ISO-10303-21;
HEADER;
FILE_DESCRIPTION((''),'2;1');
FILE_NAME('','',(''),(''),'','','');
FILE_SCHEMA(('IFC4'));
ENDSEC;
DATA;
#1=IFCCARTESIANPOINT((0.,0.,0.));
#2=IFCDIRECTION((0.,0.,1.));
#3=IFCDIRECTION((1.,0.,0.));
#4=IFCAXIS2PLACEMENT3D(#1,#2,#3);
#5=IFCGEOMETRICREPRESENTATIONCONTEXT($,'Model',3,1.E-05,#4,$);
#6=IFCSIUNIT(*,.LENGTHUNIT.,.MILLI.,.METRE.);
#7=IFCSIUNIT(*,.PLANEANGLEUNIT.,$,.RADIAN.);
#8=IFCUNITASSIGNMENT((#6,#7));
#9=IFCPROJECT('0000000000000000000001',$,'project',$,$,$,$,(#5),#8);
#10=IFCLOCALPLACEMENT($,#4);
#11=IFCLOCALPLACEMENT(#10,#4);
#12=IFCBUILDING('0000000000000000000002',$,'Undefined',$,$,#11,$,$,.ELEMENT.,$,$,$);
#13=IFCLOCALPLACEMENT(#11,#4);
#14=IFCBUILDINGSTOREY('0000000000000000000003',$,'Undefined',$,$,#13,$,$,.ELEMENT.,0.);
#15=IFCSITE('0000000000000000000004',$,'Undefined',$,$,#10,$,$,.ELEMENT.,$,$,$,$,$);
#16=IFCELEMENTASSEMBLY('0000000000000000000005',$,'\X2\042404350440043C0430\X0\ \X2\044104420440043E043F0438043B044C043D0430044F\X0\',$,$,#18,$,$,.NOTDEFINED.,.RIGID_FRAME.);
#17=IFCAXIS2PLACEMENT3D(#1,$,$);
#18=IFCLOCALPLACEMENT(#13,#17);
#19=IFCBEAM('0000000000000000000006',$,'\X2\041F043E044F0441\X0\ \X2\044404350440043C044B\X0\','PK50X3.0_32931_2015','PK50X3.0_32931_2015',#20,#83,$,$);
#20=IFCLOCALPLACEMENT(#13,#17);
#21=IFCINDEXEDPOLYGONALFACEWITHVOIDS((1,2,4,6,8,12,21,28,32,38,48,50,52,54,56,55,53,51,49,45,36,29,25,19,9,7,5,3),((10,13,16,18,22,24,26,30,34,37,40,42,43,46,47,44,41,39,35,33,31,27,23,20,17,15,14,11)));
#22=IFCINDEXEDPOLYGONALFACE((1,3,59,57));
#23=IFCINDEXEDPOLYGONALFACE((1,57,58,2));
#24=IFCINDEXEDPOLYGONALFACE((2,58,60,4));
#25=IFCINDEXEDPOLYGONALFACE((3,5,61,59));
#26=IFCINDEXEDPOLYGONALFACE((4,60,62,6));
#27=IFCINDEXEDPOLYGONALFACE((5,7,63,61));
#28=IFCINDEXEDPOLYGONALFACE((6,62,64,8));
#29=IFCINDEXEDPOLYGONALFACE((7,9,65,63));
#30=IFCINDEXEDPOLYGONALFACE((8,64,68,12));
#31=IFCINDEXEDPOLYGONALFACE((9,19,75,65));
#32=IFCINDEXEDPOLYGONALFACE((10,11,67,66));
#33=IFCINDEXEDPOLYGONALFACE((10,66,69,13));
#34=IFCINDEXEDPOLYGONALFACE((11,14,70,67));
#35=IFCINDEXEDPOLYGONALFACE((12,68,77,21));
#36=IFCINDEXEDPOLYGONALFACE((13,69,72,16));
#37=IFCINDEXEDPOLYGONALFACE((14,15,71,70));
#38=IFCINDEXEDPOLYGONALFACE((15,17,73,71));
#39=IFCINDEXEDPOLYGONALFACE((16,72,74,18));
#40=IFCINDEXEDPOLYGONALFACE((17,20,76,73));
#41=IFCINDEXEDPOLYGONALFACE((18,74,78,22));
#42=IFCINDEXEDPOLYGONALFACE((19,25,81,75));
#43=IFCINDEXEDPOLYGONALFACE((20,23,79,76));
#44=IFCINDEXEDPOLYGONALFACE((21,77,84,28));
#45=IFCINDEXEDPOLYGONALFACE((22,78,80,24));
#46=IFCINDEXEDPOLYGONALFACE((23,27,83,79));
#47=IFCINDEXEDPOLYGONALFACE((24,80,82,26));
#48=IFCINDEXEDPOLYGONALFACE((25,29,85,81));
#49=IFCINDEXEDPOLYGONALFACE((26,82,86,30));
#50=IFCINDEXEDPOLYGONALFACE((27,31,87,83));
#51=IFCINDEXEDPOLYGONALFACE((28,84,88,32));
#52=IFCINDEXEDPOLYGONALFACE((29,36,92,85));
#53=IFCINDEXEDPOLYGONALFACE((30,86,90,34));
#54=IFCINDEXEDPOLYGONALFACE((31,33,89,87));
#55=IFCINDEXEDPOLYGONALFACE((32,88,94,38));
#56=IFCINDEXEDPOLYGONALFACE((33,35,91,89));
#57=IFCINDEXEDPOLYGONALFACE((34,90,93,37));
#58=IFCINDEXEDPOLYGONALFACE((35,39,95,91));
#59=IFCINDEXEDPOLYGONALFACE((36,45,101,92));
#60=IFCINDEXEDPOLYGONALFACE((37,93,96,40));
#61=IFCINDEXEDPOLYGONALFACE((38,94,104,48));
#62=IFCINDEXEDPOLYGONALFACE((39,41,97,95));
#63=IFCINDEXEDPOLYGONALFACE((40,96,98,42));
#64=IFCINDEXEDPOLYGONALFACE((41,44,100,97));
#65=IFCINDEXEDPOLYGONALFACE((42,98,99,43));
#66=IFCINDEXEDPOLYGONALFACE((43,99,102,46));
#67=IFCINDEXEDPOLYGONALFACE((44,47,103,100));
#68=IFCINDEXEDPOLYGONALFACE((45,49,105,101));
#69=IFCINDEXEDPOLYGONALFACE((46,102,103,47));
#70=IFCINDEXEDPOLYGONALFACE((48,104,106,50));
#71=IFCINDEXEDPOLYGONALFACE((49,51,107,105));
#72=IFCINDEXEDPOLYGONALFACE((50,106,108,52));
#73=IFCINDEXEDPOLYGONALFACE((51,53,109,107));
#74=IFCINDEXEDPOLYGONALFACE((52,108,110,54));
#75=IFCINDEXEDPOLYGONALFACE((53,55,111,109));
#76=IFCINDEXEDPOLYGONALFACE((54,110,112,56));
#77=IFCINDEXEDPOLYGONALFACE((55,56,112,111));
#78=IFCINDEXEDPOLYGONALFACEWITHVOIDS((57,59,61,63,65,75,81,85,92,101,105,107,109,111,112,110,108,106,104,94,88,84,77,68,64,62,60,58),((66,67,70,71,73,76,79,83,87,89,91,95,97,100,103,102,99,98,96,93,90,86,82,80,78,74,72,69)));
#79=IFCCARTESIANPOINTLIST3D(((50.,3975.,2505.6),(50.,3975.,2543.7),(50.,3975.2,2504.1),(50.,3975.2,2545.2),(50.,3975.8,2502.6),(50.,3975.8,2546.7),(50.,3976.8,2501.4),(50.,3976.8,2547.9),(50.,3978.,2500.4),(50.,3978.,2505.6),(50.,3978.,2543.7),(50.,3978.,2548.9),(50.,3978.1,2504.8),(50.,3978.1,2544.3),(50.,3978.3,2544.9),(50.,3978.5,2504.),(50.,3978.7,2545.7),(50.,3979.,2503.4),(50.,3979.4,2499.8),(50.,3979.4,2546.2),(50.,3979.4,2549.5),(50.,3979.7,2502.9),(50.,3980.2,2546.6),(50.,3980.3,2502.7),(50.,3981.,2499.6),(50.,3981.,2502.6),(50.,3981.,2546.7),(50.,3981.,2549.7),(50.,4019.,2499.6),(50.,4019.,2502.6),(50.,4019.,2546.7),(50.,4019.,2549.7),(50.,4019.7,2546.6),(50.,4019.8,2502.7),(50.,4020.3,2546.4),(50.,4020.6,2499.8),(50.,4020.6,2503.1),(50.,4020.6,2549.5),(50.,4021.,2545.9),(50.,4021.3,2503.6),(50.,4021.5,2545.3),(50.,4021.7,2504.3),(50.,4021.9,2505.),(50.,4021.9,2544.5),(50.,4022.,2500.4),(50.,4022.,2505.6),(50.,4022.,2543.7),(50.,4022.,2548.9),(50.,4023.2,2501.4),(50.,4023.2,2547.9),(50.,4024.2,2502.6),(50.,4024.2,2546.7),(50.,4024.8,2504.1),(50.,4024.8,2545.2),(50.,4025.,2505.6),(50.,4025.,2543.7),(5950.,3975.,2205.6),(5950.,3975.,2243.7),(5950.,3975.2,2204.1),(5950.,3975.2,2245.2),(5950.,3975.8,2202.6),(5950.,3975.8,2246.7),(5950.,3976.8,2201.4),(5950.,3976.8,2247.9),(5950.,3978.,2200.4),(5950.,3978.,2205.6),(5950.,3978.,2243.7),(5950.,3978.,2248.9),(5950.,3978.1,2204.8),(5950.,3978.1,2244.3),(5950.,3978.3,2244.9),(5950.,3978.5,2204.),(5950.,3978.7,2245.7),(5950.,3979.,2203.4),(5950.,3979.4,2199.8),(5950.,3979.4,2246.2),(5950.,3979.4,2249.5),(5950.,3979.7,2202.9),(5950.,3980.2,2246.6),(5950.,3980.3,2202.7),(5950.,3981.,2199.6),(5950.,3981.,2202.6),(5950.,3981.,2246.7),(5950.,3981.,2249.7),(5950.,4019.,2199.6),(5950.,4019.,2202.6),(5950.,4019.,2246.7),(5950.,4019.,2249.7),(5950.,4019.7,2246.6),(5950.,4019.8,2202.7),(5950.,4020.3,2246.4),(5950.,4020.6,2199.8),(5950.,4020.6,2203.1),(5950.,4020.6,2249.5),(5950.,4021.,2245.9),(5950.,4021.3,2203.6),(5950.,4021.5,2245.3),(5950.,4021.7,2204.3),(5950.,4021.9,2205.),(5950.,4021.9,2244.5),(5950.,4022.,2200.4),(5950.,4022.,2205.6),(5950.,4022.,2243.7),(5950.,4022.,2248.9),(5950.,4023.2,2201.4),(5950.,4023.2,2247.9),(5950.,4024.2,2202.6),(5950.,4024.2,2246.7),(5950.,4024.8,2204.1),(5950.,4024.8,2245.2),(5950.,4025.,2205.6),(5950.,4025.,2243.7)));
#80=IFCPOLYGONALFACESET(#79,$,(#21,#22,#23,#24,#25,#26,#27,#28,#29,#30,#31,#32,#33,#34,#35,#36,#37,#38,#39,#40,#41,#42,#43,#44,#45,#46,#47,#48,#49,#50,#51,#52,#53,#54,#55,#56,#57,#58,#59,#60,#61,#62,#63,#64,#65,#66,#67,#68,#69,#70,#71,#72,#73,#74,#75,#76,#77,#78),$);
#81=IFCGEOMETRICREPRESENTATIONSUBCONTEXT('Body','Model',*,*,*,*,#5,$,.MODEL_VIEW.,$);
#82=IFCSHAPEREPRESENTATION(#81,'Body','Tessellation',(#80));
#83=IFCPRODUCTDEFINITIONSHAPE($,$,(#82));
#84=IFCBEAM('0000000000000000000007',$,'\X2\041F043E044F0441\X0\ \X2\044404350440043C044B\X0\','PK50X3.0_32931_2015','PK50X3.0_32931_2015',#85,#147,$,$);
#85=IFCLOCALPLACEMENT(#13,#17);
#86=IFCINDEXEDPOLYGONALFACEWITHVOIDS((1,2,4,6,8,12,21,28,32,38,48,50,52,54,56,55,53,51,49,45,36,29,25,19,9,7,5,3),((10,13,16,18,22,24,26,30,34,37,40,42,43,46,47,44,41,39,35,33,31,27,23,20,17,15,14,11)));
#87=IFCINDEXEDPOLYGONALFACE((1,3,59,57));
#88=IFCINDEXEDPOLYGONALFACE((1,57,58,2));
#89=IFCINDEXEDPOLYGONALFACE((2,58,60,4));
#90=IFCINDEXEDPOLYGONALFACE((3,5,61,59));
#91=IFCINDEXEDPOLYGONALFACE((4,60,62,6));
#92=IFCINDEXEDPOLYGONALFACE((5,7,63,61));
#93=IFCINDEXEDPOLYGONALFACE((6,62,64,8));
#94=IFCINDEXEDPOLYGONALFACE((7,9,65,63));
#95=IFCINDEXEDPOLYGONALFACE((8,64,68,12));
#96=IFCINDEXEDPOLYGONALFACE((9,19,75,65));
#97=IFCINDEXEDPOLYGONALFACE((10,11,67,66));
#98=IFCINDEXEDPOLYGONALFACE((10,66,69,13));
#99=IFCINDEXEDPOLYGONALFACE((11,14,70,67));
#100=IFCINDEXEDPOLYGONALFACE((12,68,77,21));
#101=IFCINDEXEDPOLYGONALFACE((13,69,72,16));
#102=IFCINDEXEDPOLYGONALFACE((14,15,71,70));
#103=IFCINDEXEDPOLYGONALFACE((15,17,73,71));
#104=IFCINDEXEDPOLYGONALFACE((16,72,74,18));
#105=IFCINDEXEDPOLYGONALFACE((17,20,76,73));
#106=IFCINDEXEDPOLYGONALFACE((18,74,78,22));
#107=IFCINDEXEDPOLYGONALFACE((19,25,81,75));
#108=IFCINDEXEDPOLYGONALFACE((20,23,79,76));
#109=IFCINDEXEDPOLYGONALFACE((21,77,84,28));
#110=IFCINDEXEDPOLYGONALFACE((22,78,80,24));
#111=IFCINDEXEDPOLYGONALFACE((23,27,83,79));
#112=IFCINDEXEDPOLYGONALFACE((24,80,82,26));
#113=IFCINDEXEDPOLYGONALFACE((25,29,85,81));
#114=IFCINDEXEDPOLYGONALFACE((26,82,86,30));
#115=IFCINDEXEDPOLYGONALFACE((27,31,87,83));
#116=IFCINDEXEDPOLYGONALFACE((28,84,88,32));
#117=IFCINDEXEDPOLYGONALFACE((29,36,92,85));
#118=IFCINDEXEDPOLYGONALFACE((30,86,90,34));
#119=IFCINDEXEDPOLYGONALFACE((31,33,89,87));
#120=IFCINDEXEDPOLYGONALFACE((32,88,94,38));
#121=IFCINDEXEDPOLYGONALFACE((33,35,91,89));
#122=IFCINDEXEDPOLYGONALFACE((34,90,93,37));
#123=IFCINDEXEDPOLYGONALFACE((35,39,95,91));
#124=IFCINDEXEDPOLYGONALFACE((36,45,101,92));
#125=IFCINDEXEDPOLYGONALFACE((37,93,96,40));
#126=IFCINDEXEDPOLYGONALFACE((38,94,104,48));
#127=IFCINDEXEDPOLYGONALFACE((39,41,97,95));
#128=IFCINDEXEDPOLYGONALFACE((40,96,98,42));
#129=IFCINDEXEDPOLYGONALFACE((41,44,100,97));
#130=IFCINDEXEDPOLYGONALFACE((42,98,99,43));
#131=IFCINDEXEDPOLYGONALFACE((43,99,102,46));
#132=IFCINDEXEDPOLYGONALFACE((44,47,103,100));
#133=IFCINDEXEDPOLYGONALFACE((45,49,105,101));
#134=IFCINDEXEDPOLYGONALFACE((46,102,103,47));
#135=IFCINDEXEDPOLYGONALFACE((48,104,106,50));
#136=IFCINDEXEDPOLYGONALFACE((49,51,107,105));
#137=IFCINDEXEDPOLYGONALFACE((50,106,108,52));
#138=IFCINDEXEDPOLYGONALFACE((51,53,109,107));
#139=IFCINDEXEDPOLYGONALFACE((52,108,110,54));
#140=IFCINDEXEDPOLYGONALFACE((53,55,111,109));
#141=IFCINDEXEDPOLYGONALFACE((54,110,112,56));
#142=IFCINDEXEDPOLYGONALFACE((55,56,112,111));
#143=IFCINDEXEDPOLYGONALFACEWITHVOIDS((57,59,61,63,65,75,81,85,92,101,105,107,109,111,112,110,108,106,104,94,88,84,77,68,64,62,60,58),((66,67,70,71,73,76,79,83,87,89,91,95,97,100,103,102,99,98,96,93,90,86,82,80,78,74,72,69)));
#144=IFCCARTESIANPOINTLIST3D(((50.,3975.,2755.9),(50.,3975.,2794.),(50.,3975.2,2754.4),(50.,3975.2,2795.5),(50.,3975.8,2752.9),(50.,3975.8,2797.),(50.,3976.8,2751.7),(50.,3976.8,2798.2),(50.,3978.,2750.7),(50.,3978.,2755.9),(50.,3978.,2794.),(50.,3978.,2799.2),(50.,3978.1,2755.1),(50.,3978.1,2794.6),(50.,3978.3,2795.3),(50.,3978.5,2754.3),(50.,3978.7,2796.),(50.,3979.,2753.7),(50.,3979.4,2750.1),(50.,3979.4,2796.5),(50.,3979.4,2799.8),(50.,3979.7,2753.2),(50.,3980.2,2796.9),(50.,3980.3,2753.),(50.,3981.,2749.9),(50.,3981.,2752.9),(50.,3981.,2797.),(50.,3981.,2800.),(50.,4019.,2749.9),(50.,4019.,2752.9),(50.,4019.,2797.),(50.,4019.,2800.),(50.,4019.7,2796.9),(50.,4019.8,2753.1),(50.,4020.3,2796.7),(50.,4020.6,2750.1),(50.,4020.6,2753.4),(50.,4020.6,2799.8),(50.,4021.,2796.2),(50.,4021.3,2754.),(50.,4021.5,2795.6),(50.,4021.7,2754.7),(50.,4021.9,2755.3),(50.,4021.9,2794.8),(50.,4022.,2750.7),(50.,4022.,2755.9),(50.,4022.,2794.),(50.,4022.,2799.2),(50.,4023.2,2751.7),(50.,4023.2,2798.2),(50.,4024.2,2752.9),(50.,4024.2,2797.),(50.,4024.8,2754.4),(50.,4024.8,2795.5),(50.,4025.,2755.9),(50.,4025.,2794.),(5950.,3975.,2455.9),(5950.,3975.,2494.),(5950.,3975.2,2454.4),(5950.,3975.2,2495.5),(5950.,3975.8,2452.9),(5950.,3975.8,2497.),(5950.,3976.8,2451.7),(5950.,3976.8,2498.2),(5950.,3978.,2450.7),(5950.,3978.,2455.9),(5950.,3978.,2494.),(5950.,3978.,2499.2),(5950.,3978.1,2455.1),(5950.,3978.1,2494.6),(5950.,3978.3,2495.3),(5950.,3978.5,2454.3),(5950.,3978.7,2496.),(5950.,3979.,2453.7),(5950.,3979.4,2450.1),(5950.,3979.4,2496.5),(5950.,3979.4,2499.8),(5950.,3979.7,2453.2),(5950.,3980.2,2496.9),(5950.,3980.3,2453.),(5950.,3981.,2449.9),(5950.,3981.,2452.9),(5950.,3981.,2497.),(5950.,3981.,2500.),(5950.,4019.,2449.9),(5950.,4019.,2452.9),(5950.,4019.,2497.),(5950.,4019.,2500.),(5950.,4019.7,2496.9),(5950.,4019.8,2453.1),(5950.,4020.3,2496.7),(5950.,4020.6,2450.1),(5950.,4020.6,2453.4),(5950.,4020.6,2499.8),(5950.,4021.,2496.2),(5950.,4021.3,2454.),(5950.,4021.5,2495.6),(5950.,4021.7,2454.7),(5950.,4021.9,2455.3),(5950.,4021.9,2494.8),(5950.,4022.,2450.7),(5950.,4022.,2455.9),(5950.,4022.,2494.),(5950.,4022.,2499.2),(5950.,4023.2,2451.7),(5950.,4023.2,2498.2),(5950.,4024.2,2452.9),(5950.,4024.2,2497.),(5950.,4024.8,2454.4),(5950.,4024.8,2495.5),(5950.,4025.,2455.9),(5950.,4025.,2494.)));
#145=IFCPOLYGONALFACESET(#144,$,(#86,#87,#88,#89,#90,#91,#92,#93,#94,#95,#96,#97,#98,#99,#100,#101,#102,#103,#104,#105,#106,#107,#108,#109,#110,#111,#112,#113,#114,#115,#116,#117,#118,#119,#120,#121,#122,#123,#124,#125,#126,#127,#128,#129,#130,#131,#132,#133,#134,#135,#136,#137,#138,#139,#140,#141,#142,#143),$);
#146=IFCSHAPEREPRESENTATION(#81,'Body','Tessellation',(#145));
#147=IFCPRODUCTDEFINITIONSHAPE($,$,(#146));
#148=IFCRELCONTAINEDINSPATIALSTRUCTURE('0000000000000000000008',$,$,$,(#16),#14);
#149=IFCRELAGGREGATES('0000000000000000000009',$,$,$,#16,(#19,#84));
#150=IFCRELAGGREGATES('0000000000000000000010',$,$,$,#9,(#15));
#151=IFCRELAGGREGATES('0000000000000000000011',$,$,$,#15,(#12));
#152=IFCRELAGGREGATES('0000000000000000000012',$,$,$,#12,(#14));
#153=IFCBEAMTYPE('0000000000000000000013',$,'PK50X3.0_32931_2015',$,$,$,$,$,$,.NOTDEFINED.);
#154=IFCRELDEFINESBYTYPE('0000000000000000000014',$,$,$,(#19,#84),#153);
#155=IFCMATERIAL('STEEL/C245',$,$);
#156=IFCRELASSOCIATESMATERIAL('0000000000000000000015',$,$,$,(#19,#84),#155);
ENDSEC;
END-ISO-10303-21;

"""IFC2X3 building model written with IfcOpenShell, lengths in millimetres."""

from ifc_helpers import new_model, si_unit, frame, origin_with_axes, origin_2d_with_axis, place, context, subcontext, project, spatial, hollow_rectangle, extrude, clip, halfspace, material, type_object, element, aggregate, save


model = new_model("IFC2X3")

# Units and contexts
model_context = context("Model", 3, precision=1e-05, world=origin_with_axes())
body_context = subcontext(model_context, "Body", "Model", "MODEL_VIEW")
ifc_project = project(units=[si_unit("LENGTHUNIT", "METRE", prefix="MILLI"), si_unit("PLANEANGLEUNIT", "RADIAN")], contexts=[model_context])

# Site, building, storey
site_placement = place(None, origin_with_axes())
site = spatial("IfcSite", under=ifc_project, at=site_placement, Name="Undefined", CompositionType="ELEMENT")
building_placement = place(site_placement, origin_with_axes())
building = spatial("IfcBuilding", under=site, at=building_placement, Name="Undefined", CompositionType="ELEMENT")
storey_placement = place(building_placement, origin_with_axes())
storey = spatial("IfcBuildingStorey", under=building, at=storey_placement, Name="Undefined", CompositionType="ELEMENT", Elevation=0.0)

# Shared definitions
ifc_material_1 = material(Name="STEEL/C245")

# Element assembly
assembly_1_placement = place(storey_placement, origin_with_axes())
assembly_1 = element("IfcElementAssembly", 1, at=assembly_1_placement, inside=storey, Name="Ферма стропильная", AssemblyPlace="NOTDEFINED", PredefinedType="RIGID_FRAME")

# Beams
beam_type_1 = type_object("IfcBeamType", Name="PK50X3.0_32931_2015", PredefinedType="NOTDEFINED")
beam_1_placement = place(assembly_1_placement, frame((36.0, 4000.0, 2525.4), z_axis=(0.050782, 0.0, 0.99871), x_axis=(0.99871, 0.0, -0.050782)))
beam_1 = element("IfcBeam", 2, at=beam_1_placement, type_object=beam_type_1, material=ifc_material_1, Name="Пояс фермы", Description="PK50X3.0_32931_2015", ObjectType="PK50X3.0_32931_2015", context=body_context, shape_type="Clipping", body=[
    clip(clip(extrude(hollow_rectangle(XDim=50.0, YDim=50.0, WallThickness=3.0, InnerFilletRadius=3.0, OuterFilletRadius=6.0, at=origin_2d_with_axis()), frame((5924.2, 0.0, 0.0), z_axis=(-1.0, 0.0, 0.0), x_axis=(0.0, -1.0, 0.0)), (0.0, 0.0, 1.0), 5912.8), halfspace(frame((5907.6, 0.0, 275.0), z_axis=(0.99871, 0.0, 0.050782), x_axis=(0.0, -1.0, 0.0)), False)), halfspace(frame((0.0, 0.0, 275.0), z_axis=(0.99871, 0.0, 0.050782), x_axis=(0.0, -1.0, 0.0)), True)),
])
beam_2_placement = place(assembly_1_placement, frame((48.7, 4000.0, 2775.0), z_axis=(0.050782, 0.0, 0.99871), x_axis=(0.99871, 0.0, -0.050782)))
beam_2 = element("IfcBeam", 3, at=beam_2_placement, type_object=beam_type_1, material=ifc_material_1, Name="Пояс фермы", Description="PK50X3.0_32931_2015", ObjectType="PK50X3.0_32931_2015", context=body_context, shape_type="Clipping", body=[
    clip(clip(extrude(hollow_rectangle(XDim=50.0, YDim=50.0, WallThickness=3.0, InnerFilletRadius=3.0, OuterFilletRadius=6.0, at=origin_2d_with_axis()), frame((5911.5, 0.0, 0.0), z_axis=(-1.0, 0.0, 0.0), x_axis=(0.0, -1.0, 0.0)), (0.0, 0.0, 1.0), 5912.8), halfspace(frame((5907.6, 0.0, 25.0), z_axis=(0.99871, 0.0, 0.050782), x_axis=(0.0, -1.0, 0.0)), False)), halfspace(frame((0.0, 0.0, 25.0), z_axis=(0.99871, 0.0, 0.050782), x_axis=(0.0, -1.0, 0.0)), True)),
])
aggregate(assembly_1, [beam_1, beam_2])

save(model, "model.ifc")
